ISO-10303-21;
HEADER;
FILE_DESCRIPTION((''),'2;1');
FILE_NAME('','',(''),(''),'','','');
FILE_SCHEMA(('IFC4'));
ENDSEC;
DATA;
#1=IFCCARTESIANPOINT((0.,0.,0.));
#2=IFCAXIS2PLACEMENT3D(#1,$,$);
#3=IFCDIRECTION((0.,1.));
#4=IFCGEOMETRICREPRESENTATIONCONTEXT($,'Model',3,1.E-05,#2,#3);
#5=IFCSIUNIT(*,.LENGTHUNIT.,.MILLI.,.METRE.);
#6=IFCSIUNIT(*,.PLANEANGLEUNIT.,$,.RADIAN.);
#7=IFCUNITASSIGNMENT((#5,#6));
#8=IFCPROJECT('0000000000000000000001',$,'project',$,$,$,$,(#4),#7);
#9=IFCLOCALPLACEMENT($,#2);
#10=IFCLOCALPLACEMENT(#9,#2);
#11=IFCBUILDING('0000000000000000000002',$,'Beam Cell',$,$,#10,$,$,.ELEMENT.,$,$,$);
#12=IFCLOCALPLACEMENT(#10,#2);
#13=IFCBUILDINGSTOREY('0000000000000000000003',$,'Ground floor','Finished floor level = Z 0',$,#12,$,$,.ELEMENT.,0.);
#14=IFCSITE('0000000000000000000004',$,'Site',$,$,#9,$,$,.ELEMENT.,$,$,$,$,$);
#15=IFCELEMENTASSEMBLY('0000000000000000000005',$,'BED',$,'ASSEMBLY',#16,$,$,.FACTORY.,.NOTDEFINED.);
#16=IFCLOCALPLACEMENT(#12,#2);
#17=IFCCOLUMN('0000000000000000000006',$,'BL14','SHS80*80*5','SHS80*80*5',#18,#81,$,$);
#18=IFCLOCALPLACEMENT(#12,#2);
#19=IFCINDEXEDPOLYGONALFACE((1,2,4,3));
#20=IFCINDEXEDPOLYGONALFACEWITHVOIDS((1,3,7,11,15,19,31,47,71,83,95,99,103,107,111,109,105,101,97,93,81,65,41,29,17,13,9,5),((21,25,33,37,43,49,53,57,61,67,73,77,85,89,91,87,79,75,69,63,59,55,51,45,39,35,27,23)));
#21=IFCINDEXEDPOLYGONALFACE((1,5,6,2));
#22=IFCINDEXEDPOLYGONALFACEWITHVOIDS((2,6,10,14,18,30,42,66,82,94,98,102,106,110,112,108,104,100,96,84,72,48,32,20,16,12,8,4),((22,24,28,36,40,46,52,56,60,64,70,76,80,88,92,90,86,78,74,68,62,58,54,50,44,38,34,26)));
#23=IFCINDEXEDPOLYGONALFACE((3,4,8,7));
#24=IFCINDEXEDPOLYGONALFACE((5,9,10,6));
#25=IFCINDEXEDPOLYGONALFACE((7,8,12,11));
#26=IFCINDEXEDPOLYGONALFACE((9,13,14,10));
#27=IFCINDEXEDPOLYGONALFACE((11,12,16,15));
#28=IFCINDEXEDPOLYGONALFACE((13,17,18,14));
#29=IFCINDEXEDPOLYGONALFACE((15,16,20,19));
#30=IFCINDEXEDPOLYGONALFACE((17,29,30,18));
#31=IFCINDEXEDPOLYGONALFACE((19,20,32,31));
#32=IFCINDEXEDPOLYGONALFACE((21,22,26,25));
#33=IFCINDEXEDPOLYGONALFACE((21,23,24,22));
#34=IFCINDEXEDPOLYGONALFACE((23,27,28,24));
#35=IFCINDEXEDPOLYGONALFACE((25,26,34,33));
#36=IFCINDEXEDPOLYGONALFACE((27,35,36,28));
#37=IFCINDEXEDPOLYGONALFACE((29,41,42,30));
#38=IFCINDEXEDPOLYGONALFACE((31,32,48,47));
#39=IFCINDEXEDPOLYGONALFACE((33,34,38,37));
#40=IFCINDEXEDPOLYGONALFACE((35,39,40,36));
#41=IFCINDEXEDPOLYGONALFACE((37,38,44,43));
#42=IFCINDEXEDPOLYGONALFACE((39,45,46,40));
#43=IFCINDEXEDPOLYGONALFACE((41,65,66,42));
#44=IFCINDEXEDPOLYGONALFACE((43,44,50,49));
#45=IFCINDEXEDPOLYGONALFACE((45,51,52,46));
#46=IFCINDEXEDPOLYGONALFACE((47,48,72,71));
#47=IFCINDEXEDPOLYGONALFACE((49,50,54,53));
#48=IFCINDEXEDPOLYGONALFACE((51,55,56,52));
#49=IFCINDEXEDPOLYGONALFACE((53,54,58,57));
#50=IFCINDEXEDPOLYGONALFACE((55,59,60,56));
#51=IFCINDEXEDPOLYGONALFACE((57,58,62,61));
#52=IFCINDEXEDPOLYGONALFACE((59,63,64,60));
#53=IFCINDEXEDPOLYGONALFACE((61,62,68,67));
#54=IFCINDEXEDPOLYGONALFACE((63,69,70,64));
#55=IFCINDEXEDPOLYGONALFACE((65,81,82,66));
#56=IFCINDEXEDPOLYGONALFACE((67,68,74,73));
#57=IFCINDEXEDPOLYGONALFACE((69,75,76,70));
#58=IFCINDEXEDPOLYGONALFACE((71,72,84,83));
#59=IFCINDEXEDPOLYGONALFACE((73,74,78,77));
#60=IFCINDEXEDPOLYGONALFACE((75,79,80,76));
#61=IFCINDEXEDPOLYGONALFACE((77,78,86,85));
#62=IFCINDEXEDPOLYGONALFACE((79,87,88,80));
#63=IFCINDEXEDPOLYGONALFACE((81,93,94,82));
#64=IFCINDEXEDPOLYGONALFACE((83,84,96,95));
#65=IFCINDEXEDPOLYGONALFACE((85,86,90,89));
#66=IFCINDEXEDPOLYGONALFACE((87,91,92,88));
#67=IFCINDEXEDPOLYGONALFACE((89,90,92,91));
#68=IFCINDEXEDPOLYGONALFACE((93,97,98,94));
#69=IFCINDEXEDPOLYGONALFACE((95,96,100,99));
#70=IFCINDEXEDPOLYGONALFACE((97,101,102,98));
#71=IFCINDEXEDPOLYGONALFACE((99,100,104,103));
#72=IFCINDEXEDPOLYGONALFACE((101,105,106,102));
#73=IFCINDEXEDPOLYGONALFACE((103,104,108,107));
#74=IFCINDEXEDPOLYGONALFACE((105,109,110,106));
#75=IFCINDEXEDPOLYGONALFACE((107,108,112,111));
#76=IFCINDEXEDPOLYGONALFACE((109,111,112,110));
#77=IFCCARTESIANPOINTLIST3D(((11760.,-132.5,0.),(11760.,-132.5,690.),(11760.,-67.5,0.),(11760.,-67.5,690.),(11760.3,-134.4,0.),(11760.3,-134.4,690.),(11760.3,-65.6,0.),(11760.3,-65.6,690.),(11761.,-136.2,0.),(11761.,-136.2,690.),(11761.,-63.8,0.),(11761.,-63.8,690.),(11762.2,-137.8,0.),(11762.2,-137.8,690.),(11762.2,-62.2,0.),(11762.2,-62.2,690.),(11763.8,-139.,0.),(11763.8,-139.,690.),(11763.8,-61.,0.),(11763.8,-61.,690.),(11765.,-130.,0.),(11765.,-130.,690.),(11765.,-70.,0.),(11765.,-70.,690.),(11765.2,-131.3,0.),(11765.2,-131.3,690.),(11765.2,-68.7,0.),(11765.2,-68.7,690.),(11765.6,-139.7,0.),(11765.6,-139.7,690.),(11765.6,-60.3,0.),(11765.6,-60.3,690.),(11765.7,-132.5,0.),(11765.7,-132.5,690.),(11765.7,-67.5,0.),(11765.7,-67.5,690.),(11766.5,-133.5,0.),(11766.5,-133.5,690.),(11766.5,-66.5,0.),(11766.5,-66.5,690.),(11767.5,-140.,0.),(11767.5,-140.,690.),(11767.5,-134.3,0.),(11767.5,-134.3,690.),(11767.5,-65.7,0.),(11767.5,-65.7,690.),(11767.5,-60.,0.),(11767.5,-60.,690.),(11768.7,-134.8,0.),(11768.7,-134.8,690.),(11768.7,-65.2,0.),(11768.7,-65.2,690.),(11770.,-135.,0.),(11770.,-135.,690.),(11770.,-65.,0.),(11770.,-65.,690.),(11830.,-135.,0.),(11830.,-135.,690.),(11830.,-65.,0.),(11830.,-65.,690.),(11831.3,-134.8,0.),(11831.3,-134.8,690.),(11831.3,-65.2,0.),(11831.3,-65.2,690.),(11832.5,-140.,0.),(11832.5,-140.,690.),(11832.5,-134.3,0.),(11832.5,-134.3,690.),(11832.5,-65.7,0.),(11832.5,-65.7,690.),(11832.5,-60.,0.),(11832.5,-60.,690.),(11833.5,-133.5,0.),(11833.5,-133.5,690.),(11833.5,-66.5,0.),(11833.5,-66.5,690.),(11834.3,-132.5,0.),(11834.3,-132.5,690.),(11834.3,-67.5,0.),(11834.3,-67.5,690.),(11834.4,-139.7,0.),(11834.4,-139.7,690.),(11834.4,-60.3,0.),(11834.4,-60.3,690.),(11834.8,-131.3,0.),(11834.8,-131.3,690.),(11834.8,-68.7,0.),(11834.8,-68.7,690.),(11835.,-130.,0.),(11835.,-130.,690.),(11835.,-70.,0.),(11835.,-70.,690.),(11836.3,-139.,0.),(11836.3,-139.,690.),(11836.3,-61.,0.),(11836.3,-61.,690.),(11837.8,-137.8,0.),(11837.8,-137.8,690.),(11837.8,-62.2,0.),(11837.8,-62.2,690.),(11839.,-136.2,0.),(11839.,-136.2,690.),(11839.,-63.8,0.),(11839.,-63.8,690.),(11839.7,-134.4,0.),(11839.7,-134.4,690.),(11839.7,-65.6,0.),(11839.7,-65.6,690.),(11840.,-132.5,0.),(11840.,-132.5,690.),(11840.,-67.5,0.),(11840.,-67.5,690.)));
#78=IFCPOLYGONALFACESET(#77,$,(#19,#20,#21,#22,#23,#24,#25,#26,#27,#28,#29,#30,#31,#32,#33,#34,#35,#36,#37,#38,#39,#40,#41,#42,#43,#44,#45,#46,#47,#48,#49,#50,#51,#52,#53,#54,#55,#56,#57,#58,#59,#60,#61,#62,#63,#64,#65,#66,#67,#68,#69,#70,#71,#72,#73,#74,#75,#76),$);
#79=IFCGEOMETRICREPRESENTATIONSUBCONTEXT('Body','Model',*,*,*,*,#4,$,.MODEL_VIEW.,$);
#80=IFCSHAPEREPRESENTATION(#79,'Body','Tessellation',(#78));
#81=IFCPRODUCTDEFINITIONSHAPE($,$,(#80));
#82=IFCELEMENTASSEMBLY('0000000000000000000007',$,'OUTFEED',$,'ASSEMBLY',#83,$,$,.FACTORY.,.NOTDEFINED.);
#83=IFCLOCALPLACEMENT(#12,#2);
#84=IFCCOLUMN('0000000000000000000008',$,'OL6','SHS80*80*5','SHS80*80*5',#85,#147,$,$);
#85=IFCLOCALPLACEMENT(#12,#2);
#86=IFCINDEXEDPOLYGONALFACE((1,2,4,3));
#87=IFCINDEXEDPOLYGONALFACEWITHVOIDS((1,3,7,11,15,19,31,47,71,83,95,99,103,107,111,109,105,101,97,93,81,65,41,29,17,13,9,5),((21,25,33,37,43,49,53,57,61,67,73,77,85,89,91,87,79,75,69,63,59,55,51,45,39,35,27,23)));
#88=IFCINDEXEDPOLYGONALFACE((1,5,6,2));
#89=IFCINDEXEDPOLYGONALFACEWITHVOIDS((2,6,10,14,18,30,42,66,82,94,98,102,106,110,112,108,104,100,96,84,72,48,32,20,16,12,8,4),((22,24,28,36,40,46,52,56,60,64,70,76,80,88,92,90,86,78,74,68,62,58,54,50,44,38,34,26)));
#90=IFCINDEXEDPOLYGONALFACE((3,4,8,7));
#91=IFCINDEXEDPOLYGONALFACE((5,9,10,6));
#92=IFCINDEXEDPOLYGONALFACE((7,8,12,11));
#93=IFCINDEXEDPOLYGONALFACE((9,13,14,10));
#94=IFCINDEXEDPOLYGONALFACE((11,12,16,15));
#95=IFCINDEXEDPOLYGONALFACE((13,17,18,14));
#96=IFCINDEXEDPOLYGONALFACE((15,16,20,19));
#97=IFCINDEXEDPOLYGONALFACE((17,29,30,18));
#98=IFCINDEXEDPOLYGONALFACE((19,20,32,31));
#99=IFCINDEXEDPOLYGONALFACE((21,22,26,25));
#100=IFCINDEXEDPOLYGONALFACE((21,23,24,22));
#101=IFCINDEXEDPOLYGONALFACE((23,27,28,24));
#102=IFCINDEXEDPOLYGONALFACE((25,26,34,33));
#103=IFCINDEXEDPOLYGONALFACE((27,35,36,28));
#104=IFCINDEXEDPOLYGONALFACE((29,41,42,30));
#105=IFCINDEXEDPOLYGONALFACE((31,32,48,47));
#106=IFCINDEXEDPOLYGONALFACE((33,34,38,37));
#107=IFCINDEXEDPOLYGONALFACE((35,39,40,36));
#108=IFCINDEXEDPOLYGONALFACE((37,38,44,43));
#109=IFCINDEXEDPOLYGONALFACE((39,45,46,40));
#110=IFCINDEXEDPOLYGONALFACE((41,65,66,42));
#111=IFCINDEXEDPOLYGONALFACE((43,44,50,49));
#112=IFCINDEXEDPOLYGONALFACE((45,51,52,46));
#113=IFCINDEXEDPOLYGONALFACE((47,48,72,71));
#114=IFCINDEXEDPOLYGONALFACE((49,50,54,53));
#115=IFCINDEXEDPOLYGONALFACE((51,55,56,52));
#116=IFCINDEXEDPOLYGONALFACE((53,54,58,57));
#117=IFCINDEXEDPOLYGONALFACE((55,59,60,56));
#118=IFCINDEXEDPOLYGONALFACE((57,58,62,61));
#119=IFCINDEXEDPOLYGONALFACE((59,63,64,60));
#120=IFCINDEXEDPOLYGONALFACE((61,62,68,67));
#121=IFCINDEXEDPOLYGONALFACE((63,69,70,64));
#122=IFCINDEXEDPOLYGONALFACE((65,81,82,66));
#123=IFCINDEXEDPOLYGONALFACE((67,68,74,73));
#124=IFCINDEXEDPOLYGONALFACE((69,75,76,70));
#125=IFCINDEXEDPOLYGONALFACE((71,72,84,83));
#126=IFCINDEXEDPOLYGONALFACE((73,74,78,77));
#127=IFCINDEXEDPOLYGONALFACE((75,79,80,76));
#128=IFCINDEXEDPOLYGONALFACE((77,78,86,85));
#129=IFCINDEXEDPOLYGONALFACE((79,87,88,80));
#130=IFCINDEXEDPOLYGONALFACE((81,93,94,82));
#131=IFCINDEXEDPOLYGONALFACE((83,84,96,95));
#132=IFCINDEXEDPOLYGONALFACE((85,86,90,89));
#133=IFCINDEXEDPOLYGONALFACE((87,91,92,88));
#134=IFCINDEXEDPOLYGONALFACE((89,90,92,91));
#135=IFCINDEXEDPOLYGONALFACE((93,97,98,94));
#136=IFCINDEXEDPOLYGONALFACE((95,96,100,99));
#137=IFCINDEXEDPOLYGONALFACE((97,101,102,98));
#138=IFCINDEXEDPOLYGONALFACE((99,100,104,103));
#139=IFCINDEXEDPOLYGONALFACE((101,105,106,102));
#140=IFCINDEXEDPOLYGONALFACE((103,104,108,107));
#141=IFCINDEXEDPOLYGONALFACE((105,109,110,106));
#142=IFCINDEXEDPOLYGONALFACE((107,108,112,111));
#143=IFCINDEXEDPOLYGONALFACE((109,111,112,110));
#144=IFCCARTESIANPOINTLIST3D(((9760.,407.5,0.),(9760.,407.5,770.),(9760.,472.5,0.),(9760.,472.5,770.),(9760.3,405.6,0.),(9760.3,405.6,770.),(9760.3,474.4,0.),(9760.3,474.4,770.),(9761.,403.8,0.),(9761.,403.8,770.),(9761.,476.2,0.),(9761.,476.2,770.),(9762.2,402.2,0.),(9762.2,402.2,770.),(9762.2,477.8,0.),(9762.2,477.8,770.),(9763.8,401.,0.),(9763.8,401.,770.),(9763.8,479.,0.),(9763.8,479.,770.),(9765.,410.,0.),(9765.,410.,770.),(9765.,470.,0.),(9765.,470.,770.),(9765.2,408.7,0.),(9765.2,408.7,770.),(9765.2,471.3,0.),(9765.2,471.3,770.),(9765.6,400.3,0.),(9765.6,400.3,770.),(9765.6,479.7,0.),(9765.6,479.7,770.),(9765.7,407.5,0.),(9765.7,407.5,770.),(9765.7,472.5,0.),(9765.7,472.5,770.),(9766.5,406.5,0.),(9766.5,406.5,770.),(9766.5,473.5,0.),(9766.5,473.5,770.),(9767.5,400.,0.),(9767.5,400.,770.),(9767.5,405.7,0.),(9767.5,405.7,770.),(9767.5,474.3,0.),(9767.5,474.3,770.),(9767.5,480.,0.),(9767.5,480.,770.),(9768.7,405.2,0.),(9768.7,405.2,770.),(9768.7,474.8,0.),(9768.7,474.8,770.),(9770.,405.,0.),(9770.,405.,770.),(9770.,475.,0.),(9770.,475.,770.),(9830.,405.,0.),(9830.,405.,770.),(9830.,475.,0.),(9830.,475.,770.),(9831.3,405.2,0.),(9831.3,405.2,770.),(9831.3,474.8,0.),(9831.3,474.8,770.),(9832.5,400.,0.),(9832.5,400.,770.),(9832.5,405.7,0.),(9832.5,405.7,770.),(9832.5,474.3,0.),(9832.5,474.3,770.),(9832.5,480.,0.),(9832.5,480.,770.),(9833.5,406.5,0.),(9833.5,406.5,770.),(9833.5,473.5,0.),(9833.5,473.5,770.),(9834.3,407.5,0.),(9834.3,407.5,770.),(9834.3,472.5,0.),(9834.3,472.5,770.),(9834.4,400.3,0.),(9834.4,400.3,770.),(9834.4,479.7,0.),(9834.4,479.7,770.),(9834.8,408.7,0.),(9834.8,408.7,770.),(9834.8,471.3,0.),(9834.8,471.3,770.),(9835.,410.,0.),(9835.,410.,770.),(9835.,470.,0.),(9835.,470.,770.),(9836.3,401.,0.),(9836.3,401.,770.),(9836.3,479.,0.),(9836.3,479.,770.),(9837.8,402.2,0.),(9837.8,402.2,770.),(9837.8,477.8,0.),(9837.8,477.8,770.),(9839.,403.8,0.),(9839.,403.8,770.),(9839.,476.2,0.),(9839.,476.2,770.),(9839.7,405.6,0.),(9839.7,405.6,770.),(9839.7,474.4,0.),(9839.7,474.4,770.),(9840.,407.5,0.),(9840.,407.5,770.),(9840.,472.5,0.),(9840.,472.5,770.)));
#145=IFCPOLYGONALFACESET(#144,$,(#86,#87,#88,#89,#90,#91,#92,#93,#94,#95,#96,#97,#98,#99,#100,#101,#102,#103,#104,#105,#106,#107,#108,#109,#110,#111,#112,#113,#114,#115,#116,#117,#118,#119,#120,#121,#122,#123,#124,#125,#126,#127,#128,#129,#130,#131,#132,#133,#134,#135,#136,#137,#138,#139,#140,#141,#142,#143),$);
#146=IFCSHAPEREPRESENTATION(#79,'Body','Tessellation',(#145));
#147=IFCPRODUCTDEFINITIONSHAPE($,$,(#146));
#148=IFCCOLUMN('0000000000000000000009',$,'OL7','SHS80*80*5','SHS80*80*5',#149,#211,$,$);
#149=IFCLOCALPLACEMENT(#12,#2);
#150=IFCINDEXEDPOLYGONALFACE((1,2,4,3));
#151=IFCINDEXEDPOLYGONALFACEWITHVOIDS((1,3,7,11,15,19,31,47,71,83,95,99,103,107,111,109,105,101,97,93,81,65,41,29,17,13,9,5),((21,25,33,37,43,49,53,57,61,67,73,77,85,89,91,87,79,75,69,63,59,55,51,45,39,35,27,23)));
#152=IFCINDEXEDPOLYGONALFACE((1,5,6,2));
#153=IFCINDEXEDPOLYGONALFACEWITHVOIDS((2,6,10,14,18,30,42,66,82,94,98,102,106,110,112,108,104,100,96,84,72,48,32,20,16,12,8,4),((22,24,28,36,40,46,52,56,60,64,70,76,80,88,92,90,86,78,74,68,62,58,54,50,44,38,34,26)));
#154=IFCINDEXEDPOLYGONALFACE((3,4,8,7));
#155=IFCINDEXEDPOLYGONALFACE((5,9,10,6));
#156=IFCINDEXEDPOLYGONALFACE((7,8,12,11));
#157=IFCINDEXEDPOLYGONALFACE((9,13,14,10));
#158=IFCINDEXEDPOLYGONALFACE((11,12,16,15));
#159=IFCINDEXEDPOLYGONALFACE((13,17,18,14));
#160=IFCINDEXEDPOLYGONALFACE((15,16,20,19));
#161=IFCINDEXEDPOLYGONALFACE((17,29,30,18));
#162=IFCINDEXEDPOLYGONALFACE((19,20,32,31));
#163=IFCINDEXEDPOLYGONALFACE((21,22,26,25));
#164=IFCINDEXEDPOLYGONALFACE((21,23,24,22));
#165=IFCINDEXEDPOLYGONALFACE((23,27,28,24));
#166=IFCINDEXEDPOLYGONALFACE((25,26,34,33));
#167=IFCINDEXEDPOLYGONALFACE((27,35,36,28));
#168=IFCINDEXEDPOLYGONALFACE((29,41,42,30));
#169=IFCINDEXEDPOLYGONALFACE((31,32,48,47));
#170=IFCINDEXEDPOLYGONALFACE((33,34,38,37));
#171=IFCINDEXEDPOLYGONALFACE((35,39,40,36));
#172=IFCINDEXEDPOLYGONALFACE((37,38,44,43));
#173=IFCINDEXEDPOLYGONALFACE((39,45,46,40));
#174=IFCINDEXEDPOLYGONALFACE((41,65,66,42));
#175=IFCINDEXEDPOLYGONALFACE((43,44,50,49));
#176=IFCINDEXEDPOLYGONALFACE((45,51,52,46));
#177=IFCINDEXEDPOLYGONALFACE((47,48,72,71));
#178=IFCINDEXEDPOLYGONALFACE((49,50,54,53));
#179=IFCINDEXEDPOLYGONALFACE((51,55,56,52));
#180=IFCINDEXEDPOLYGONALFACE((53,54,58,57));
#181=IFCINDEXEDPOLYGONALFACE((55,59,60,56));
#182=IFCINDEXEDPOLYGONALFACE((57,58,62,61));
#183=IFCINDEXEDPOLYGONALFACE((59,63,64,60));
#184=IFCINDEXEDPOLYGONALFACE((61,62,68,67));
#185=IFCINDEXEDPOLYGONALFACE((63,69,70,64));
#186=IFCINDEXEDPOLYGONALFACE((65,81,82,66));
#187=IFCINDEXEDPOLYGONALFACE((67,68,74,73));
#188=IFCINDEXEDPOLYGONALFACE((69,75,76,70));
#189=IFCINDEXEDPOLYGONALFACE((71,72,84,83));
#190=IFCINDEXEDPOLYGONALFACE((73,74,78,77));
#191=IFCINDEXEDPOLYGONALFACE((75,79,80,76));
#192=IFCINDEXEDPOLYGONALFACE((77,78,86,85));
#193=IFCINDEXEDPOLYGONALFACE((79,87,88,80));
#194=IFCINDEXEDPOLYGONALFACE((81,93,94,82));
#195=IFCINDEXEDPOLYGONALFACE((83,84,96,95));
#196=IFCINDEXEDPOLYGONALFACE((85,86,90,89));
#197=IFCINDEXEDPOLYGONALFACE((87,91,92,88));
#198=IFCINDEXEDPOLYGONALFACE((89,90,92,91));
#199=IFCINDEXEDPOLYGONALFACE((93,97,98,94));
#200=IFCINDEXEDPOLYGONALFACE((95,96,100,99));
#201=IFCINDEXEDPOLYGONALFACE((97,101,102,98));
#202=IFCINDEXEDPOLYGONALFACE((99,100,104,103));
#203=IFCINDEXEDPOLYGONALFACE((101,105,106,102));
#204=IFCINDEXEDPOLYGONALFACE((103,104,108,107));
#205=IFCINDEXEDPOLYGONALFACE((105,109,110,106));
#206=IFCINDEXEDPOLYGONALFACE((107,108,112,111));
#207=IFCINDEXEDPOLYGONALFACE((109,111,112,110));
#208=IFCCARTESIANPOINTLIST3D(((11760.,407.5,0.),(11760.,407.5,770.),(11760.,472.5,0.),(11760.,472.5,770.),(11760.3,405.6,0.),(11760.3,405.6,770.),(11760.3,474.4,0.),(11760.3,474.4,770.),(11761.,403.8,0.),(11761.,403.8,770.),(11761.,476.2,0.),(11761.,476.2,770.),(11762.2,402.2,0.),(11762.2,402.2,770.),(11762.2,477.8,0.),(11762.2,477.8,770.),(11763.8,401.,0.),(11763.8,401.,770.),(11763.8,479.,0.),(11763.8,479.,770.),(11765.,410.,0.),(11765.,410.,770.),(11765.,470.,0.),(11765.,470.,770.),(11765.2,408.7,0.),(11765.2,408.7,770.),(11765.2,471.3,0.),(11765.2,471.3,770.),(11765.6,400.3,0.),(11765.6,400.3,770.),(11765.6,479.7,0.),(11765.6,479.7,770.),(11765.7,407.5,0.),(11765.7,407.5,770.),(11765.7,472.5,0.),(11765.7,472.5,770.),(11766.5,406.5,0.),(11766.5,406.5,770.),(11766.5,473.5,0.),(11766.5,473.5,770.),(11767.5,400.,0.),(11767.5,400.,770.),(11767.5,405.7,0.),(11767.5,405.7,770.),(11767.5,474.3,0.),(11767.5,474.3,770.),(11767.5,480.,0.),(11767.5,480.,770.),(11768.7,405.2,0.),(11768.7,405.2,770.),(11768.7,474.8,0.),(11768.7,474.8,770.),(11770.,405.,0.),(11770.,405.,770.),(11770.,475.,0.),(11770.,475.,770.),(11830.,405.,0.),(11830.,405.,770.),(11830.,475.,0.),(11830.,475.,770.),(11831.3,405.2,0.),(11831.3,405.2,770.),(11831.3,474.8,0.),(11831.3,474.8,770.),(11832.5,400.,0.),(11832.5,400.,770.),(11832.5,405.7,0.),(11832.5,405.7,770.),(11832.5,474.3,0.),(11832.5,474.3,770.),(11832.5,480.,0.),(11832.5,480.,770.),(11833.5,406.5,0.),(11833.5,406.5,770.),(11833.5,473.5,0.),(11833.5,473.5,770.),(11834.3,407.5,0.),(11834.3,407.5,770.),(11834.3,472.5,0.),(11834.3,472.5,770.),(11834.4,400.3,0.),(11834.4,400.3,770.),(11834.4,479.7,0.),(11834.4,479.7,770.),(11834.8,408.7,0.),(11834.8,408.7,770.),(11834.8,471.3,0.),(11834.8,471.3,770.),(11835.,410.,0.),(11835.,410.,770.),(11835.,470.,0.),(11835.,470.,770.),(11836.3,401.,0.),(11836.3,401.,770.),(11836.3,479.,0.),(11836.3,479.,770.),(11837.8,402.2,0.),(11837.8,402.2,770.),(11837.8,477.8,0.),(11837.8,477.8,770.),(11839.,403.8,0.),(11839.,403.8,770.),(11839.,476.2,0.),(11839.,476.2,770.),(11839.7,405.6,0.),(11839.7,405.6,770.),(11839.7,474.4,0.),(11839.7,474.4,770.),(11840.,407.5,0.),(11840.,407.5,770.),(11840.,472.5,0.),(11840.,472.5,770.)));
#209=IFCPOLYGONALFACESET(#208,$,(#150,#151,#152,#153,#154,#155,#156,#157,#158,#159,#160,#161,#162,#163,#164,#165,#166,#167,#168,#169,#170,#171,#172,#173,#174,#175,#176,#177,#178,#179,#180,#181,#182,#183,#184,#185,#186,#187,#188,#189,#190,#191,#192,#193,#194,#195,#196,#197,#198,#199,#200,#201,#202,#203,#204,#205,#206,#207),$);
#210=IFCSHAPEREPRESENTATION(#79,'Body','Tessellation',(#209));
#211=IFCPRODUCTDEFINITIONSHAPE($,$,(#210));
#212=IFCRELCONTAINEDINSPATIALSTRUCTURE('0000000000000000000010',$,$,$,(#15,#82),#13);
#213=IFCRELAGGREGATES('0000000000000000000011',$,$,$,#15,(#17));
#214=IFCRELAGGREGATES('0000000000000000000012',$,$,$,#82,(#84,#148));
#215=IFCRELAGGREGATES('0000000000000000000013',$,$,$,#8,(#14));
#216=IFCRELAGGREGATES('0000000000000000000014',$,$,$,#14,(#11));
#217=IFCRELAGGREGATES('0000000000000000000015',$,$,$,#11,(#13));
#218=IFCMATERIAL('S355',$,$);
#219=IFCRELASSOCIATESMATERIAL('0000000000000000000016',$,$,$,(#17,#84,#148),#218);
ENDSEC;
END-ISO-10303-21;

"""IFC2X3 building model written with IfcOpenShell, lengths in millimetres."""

from ifc_helpers import new_model, si_unit, direction, frame, origin, origin_2d, place, context, subcontext, project, spatial, hollow_rectangle, extrude, material, element, aggregate, save


model = new_model("IFC2X3")

# Units and contexts
model_context = context("Model", 3, precision=1e-05, world=origin(), true_north=direction((0.0, 1.0)))
body_context = subcontext(model_context, "Body", "Model", "MODEL_VIEW")
ifc_project = project(units=[si_unit("LENGTHUNIT", "METRE", prefix="MILLI"), si_unit("PLANEANGLEUNIT", "RADIAN")], contexts=[model_context])

# Site, building, storey
site_placement = place(None, origin())
site = spatial("IfcSite", under=ifc_project, at=site_placement, Name="Site", CompositionType="ELEMENT")
building_placement = place(site_placement, origin())
building = spatial("IfcBuilding", under=site, at=building_placement, Name="Beam Cell", CompositionType="ELEMENT")
storey_placement = place(building_placement, origin())
storey = spatial("IfcBuildingStorey", under=building, at=storey_placement, Name="Ground floor", Description="Finished floor level = Z 0", CompositionType="ELEMENT", Elevation=0.0)

# Element assemblies, columns
ifc_material = material(Name="S355")
assembly_1_placement = place(storey_placement, origin())
assembly_1 = element("IfcElementAssembly", 1, at=assembly_1_placement, inside=storey, Name="BED", ObjectType="ASSEMBLY", AssemblyPlace="FACTORY", PredefinedType="NOTDEFINED")
column_1_placement = place(storey_placement, frame((11800.0, -100.0, 0.0), z_axis=(0.0, 0.0, 1.0), x_axis=(1.0, 0.0, 0.0)))
column_1 = element("IfcColumn", 2, at=column_1_placement, material=ifc_material, Name="BL14", Description="SHS80*80*5", ObjectType="SHS80*80*5", context=body_context, shape_type="SweptSolid", body=[
    extrude(hollow_rectangle(XDim=80.0, YDim=80.0, WallThickness=5.0, InnerFilletRadius=5.0, OuterFilletRadius=7.5, at=origin_2d()), origin(), (0.0, 0.0, 1.0), 690.0),
])
aggregate(assembly_1, [column_1])
assembly_2_placement = place(storey_placement, origin())
assembly_2 = element("IfcElementAssembly", 3, at=assembly_2_placement, inside=storey, Name="OUTFEED", ObjectType="ASSEMBLY", AssemblyPlace="FACTORY", PredefinedType="NOTDEFINED")
column_2_placement = place(storey_placement, frame((9800.0, 440.0, 0.0), z_axis=(0.0, 0.0, 1.0), x_axis=(1.0, 0.0, 0.0)))
column_2 = element("IfcColumn", 4, at=column_2_placement, material=ifc_material, Name="OL6", Description="SHS80*80*5", ObjectType="SHS80*80*5", context=body_context, shape_type="SweptSolid", body=[
    extrude(hollow_rectangle(XDim=80.0, YDim=80.0, WallThickness=5.0, InnerFilletRadius=5.0, OuterFilletRadius=7.5, at=origin_2d()), origin(), (0.0, 0.0, 1.0), 770.0),
])
column_3_placement = place(storey_placement, frame((11800.0, 440.0, 0.0), z_axis=(0.0, 0.0, 1.0), x_axis=(1.0, 0.0, 0.0)))
column_3 = element("IfcColumn", 5, at=column_3_placement, material=ifc_material, Name="OL7", Description="SHS80*80*5", ObjectType="SHS80*80*5", context=body_context, shape_type="SweptSolid", body=[
    extrude(hollow_rectangle(XDim=80.0, YDim=80.0, WallThickness=5.0, InnerFilletRadius=5.0, OuterFilletRadius=7.5, at=origin_2d()), origin(), (0.0, 0.0, 1.0), 770.0),
])
aggregate(assembly_2, [column_2, column_3])

save(model, "model.ifc")
